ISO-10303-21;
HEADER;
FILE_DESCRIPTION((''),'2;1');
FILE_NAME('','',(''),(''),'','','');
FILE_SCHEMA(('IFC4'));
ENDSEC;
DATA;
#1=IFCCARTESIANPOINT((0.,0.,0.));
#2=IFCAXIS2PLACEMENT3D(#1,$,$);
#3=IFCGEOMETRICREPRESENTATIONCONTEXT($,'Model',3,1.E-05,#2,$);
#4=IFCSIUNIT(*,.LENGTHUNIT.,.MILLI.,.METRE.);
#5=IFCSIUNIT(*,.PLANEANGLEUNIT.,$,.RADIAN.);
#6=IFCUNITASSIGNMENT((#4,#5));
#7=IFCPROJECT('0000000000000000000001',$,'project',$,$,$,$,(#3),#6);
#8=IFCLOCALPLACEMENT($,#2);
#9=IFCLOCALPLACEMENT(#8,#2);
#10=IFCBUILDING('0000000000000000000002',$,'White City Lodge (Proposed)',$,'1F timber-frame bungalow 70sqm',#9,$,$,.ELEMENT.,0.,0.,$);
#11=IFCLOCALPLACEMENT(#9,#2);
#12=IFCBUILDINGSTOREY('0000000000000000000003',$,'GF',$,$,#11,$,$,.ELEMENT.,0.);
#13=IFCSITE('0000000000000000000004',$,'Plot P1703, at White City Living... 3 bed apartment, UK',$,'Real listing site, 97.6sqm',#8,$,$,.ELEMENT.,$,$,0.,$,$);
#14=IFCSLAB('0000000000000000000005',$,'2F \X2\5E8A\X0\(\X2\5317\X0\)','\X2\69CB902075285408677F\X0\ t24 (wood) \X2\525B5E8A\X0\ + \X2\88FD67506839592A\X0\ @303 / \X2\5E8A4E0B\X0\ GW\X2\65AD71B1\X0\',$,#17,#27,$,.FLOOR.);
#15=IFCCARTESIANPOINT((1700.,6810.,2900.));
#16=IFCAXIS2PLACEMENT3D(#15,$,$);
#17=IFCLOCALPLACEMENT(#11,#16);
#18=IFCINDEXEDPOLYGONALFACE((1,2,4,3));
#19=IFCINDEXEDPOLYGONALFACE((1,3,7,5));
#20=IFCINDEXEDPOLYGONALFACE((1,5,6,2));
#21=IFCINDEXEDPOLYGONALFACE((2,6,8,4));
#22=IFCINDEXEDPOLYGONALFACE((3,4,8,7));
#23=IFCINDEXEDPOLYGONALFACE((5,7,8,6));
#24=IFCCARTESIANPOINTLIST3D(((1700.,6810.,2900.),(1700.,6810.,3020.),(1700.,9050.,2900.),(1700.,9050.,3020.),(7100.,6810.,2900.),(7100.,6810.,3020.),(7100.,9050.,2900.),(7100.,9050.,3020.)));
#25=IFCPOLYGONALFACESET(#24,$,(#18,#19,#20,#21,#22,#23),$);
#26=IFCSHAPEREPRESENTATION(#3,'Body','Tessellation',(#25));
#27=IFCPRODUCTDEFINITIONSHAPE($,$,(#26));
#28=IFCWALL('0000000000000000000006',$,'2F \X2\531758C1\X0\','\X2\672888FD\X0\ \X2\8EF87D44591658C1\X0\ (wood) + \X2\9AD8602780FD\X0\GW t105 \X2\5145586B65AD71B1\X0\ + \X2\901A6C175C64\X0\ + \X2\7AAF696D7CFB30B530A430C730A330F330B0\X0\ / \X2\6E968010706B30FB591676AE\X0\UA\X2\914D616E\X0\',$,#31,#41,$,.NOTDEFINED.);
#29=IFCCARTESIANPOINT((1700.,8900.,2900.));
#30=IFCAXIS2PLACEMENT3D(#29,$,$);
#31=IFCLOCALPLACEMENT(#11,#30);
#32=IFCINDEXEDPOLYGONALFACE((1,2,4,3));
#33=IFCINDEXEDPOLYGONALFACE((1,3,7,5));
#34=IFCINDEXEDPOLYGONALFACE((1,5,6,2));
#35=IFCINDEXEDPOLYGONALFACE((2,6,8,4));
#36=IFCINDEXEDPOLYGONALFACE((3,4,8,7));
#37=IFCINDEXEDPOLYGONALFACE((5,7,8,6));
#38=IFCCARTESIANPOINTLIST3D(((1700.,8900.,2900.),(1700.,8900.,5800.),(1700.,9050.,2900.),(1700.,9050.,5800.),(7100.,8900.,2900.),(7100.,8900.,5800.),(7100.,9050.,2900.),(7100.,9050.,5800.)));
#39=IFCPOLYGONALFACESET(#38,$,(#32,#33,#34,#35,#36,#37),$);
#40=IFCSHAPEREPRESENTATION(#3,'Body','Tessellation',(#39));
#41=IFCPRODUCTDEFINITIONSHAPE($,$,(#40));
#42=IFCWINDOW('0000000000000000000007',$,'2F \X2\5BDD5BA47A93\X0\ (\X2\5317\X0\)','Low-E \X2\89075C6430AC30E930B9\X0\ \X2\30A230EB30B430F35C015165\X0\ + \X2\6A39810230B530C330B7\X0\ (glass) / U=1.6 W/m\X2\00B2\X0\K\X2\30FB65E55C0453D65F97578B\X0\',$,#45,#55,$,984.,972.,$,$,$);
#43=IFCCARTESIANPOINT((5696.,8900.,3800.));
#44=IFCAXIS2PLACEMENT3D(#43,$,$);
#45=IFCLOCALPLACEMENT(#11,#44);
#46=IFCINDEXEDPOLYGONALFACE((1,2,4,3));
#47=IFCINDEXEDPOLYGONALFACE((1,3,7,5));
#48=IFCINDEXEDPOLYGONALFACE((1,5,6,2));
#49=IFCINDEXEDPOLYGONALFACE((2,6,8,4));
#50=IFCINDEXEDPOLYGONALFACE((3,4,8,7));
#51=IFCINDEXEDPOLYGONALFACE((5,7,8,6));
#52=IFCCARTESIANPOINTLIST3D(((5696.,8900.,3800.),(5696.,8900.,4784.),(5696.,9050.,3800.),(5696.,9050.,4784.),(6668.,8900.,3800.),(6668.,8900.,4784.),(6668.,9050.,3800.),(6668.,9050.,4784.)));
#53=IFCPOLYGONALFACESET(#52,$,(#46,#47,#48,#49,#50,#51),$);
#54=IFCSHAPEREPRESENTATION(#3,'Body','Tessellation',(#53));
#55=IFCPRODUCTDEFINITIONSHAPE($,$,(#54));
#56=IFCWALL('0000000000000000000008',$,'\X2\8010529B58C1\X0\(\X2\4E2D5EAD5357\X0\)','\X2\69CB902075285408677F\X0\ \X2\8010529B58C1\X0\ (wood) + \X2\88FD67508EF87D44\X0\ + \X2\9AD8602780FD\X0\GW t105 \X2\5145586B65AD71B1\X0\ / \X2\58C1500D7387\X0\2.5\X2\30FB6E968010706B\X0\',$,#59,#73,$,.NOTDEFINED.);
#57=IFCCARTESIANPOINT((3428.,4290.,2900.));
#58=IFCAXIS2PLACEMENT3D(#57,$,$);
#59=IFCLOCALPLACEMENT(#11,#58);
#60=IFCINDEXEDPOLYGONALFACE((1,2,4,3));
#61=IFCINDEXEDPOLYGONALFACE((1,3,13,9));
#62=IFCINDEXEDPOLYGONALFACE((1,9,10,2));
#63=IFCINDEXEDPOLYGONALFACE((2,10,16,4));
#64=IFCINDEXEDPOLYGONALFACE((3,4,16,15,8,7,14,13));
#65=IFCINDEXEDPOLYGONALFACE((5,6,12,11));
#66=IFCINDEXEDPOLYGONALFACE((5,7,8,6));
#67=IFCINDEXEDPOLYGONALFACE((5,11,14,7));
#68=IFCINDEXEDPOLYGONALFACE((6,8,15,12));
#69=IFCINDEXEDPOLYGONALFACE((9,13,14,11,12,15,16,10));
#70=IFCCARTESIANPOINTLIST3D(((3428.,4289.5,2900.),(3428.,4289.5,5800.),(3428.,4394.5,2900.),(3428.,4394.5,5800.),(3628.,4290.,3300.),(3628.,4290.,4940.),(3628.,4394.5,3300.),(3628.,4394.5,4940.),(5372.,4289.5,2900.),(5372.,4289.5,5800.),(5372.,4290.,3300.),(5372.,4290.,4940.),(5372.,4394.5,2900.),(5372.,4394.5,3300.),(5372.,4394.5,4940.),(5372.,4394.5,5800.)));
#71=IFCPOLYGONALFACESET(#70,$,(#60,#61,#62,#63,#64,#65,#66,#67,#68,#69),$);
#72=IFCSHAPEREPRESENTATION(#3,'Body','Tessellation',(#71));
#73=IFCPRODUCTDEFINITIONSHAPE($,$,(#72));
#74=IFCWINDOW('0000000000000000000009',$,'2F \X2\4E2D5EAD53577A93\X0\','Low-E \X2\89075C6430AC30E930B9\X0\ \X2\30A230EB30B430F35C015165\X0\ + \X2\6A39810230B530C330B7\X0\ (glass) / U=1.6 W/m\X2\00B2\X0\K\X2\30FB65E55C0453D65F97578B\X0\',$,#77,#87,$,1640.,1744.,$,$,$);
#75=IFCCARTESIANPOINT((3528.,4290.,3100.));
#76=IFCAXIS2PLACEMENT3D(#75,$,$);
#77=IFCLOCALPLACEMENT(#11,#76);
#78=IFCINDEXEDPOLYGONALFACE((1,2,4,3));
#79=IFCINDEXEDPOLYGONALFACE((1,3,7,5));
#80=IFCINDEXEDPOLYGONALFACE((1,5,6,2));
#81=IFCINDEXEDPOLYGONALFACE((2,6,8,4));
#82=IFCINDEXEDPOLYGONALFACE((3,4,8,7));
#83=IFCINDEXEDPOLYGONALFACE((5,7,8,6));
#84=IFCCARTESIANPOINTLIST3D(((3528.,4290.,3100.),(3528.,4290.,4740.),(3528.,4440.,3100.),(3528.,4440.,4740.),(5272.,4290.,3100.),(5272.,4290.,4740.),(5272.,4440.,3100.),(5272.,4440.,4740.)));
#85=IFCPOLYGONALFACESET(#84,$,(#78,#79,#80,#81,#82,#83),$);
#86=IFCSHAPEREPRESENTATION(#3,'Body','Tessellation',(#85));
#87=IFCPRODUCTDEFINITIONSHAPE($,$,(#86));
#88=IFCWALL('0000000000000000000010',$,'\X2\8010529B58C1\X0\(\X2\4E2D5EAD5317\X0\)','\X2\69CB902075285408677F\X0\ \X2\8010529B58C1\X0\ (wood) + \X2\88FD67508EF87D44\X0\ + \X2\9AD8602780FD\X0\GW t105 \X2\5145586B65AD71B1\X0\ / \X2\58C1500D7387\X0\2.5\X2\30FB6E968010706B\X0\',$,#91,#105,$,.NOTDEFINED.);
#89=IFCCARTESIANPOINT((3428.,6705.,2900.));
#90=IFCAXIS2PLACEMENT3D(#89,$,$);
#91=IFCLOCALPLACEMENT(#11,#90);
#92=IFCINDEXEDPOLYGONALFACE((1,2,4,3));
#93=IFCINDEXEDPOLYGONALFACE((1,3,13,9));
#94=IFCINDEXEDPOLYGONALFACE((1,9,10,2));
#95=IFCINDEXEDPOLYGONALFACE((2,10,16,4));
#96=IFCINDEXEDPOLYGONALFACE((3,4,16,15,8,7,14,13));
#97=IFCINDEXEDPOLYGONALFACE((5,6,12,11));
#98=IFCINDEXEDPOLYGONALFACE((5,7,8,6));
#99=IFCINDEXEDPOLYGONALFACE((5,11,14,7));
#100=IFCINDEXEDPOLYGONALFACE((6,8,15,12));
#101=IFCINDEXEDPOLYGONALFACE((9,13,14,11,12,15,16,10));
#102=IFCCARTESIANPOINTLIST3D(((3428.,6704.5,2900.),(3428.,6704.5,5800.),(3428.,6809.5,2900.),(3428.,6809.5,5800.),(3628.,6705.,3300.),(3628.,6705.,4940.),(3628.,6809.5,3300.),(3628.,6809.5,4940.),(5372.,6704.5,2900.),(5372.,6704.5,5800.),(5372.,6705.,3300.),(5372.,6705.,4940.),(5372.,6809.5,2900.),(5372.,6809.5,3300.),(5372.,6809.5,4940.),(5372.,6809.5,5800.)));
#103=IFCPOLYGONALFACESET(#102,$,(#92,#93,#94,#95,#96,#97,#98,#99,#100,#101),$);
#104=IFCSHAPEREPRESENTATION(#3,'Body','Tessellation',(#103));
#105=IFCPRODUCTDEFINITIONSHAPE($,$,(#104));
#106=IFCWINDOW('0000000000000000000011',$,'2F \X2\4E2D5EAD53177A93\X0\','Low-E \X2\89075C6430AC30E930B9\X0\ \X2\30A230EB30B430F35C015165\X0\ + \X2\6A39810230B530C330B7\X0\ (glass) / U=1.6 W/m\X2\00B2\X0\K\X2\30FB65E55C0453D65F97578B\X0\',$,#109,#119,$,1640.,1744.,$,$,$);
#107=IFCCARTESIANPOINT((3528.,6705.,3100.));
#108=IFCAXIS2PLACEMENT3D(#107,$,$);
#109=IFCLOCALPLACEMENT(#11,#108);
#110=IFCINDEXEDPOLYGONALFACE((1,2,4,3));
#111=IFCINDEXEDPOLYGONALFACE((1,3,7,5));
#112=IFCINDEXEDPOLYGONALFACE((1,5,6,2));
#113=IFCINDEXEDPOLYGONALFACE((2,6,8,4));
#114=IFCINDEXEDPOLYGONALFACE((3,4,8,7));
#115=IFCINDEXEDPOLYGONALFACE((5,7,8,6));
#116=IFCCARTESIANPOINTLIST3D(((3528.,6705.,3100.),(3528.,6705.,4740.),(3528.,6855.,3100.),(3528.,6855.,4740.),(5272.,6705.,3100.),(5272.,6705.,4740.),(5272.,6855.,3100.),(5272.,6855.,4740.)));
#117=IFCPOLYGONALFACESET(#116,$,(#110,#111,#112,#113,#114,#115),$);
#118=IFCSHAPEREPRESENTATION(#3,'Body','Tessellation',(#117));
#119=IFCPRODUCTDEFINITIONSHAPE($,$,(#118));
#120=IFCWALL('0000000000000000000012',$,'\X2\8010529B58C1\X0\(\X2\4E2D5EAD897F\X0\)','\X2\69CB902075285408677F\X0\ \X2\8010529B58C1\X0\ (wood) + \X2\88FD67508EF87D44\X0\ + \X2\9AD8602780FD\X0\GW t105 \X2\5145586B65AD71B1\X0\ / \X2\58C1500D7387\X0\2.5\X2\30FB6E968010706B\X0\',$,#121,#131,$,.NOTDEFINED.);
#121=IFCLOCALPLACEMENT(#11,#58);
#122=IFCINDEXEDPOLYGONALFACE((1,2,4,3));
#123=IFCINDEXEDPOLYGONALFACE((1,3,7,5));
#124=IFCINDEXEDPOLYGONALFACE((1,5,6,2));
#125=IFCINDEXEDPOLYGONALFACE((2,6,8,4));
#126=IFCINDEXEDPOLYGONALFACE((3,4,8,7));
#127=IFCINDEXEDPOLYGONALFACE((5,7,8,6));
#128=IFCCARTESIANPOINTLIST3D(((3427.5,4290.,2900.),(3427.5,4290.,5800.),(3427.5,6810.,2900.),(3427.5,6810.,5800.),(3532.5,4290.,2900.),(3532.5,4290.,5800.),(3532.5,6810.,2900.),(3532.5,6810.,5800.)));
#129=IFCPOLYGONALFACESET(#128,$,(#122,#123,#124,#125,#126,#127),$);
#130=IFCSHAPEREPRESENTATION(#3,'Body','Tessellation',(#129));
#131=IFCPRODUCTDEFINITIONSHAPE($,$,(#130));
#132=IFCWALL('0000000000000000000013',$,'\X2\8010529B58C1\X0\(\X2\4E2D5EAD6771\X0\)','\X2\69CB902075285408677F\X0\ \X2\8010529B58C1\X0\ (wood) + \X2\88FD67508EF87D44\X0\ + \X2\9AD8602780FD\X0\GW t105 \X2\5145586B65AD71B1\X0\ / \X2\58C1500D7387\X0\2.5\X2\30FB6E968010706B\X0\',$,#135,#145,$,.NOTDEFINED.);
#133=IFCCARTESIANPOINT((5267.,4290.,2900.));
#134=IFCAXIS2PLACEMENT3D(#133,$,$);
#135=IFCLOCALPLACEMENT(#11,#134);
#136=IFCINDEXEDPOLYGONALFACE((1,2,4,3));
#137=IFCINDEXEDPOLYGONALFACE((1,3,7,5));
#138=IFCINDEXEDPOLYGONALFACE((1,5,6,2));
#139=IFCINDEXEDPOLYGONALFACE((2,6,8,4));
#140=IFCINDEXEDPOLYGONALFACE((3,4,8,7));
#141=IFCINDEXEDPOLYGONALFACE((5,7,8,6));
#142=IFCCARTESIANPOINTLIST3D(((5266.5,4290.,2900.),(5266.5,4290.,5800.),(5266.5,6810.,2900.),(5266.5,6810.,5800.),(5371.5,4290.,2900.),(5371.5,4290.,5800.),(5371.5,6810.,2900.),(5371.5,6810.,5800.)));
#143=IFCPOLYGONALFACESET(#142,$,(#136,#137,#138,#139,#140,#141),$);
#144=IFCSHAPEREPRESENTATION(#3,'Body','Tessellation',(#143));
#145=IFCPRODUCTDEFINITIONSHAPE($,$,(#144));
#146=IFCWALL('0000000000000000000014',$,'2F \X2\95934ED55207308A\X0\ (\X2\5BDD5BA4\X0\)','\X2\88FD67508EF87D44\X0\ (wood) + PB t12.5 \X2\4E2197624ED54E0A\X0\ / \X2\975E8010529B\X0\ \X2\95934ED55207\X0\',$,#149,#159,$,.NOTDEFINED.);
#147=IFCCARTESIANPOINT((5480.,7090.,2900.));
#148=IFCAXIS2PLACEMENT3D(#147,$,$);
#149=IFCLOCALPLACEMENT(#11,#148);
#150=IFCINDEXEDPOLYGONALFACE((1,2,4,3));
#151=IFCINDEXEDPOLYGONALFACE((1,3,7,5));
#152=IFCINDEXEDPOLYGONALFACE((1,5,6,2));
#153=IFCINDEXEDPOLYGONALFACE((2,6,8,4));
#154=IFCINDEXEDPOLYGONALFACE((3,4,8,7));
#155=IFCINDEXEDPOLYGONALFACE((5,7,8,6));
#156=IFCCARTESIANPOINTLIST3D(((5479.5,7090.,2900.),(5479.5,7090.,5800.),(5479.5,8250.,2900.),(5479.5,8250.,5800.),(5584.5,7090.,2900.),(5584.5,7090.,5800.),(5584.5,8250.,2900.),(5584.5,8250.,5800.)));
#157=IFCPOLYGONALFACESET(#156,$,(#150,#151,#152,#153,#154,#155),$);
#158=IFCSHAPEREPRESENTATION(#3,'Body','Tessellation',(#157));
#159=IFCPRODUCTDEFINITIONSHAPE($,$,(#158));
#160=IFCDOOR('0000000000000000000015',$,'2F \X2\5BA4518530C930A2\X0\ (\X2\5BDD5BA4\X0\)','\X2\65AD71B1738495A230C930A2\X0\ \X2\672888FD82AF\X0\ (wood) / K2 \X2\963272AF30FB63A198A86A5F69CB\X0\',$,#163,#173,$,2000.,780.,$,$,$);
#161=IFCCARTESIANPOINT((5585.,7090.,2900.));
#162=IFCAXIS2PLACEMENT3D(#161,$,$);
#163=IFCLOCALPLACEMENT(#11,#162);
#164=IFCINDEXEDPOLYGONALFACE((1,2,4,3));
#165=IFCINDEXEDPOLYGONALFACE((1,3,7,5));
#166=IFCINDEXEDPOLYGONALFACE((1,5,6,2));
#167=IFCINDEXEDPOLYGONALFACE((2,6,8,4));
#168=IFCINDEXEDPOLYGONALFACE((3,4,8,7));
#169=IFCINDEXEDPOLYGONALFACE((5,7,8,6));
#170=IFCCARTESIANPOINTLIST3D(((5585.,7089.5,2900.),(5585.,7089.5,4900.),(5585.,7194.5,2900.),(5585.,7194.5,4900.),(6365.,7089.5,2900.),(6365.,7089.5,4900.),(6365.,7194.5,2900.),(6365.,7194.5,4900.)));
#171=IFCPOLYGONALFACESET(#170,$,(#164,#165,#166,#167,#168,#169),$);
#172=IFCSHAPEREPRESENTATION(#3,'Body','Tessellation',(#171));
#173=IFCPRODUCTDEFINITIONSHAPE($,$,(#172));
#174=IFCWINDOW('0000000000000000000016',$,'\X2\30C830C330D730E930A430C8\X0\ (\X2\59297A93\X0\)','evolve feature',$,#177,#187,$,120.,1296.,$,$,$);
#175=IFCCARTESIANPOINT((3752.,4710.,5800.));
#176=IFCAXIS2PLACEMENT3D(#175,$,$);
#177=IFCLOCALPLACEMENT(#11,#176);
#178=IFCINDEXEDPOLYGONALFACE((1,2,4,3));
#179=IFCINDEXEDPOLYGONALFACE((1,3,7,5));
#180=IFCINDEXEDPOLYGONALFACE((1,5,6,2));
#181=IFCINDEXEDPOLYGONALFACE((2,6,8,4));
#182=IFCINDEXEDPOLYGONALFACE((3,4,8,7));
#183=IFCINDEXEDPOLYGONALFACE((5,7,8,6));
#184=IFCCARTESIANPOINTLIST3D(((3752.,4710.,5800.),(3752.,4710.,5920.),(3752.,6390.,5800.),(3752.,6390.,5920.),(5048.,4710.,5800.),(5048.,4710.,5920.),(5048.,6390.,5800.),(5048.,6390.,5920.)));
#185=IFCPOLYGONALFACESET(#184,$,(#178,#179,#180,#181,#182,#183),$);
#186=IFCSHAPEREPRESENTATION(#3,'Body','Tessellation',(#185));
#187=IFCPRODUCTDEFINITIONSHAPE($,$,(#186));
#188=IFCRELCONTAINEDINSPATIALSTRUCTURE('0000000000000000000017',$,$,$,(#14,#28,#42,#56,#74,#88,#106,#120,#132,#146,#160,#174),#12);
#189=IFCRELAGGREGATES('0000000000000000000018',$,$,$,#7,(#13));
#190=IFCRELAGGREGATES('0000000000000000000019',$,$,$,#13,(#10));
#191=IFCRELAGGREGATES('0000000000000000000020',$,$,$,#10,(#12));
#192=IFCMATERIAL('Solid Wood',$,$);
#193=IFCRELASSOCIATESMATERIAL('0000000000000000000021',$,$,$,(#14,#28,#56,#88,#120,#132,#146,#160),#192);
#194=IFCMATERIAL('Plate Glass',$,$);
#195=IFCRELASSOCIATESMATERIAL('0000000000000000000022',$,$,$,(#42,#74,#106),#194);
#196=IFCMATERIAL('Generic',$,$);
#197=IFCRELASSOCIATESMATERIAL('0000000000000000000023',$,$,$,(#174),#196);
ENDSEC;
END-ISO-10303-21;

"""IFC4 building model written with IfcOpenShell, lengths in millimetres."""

from ifc_helpers import new_model, si_unit, frame, frame_2d, origin, place, context, project, spatial, rectangle, extrude, material, element, fill, save


model = new_model("IFC4")

# Units and contexts
model_context = context("Model", 3, precision=1e-05, world=origin())
ifc_project = project(units=[si_unit("LENGTHUNIT", "METRE", prefix="MILLI"), si_unit("PLANEANGLEUNIT", "RADIAN")], contexts=[model_context])

# Site, building, storey
site_placement = place(None, origin())
site = spatial("IfcSite", under=ifc_project, at=site_placement, Name="Plot P1703, at White City Living... 3 bed apartment, UK", ObjectType="Real listing site, 97.6sqm", CompositionType="ELEMENT", RefElevation=0.0)
building_placement = place(site_placement, origin())
building = spatial("IfcBuilding", under=site, at=building_placement, Name="White City Lodge (Proposed)", ObjectType="1F timber-frame bungalow 70sqm", CompositionType="ELEMENT", ElevationOfRefHeight=0.0, ElevationOfTerrain=0.0)
storey_placement = place(building_placement, origin())
storey = spatial("IfcBuildingStorey", under=building, at=storey_placement, Name="GF", CompositionType="ELEMENT", Elevation=0.0)

# Slab
ifc_material_1 = material(Name="Solid Wood")
slab_placement = place(storey_placement, frame((1700.0, 6810.0, 2900.0)))
element("IfcSlab", 1, at=slab_placement, inside=storey, material=ifc_material_1, Name="2F 床(北)", Description="構造用合板 t24 (wood) 剛床 + 製材根太 @303 / 床下 GW断熱", PredefinedType="FLOOR", context=model_context, shape_type="SweptSolid", body=[
    extrude(rectangle(XDim=5400.0, YDim=2240.0, at=frame_2d((2700.0, 1120.0))), frame((1700.0, 6810.0, 2900.0)), (0.0, 0.0, 1.0), 120.0),
])

# Walls, openings, windows
wall_1_placement = place(storey_placement, frame((1700.0, 8900.0, 2900.0)))
wall_1 = element("IfcWall", 2, at=wall_1_placement, inside=storey, material=ifc_material_1, Name="2F 北壁", Description="木製 軸組外壁 (wood) + 高性能GW t105 充填断熱 + 通気層 + 窯業系サイディング / 準耐火・外皮UA配慮", PredefinedType="NOTDEFINED", context=model_context, shape_type="SweptSolid", body=[
    extrude(rectangle(XDim=5400.0, YDim=150.0, at=frame_2d((2700.0, 75.0))), frame((1700.0, 8900.0, 2900.0)), (0.0, 0.0, 1.0), 2900.0),
])
opening_1_placement = place(storey_placement, frame((5696.0, 8900.0, 3800.0)))
opening_1 = element("IfcOpeningElement", 3, at=opening_1_placement, cuts=wall_1, PredefinedType="NOTDEFINED", context=model_context, shape_type="SweptSolid", body=[
    extrude(rectangle(XDim=972.0, YDim=150.0, at=frame_2d((486.0, 75.0))), frame((5696.0, 8900.0, 3800.0)), (0.0, 0.0, 1.0), 984.0),
])
ifc_material_2 = material(Name="Plate Glass")
window_1_placement = place(storey_placement, frame((5696.0, 8900.0, 3800.0)))
window_1 = element("IfcWindow", 4, at=window_1_placement, inside=storey, material=ifc_material_2, Name="2F 寝室窓 (北)", Description="Low-E 複層ガラス アルゴン封入 + 樹脂サッシ (glass) / U=1.6 W/m²K・日射取得型", OverallHeight=984.0, OverallWidth=972.0, context=model_context, shape_type="SweptSolid", body=[
    extrude(rectangle(XDim=972.0, YDim=150.0, at=frame_2d((486.0, 75.0))), frame((5696.0, 8900.0, 3800.0)), (0.0, 0.0, 1.0), 984.0),
])
fill(opening_1, window_1)
wall_2_placement = place(storey_placement, frame((3428.0, 4290.0, 2900.0)))
wall_2 = element("IfcWall", 5, at=wall_2_placement, inside=storey, material=ifc_material_1, Name="耐力壁(中庭南)", Description="構造用合板 耐力壁 (wood) + 製材軸組 + 高性能GW t105 充填断熱 / 壁倍率2.5・準耐火", PredefinedType="NOTDEFINED", context=model_context, shape_type="SweptSolid", body=[
    extrude(rectangle(XDim=1944.0, YDim=105.0, at=frame_2d((972.0, 52.0))), frame((3428.0, 4290.0, 2900.0)), (0.0, 0.0, 1.0), 2900.0),
])
opening_2_placement = place(storey_placement, frame((3528.0, 4290.0, 3100.0)))
opening_2 = element("IfcOpeningElement", 6, at=opening_2_placement, cuts=wall_2, PredefinedType="NOTDEFINED", context=model_context, shape_type="SweptSolid", body=[
    extrude(rectangle(XDim=1744.0, YDim=150.0, at=frame_2d((872.0, 75.0))), frame((3528.0, 4290.0, 3100.0)), (0.0, 0.0, 1.0), 1640.0),
])
window_2_placement = place(storey_placement, frame((3528.0, 4290.0, 3100.0)))
window_2 = element("IfcWindow", 7, at=window_2_placement, inside=storey, material=ifc_material_2, Name="2F 中庭南窓", Description="Low-E 複層ガラス アルゴン封入 + 樹脂サッシ (glass) / U=1.6 W/m²K・日射取得型", OverallHeight=1640.0, OverallWidth=1744.0, context=model_context, shape_type="SweptSolid", body=[
    extrude(rectangle(XDim=1744.0, YDim=150.0, at=frame_2d((872.0, 75.0))), frame((3528.0, 4290.0, 3100.0)), (0.0, 0.0, 1.0), 1640.0),
])
fill(opening_2, window_2)
wall_3_placement = place(storey_placement, frame((3428.0, 6705.0, 2900.0)))
wall_3 = element("IfcWall", 8, at=wall_3_placement, inside=storey, material=ifc_material_1, Name="耐力壁(中庭北)", Description="構造用合板 耐力壁 (wood) + 製材軸組 + 高性能GW t105 充填断熱 / 壁倍率2.5・準耐火", PredefinedType="NOTDEFINED", context=model_context, shape_type="SweptSolid", body=[
    extrude(rectangle(XDim=1944.0, YDim=105.0, at=frame_2d((972.0, 52.0))), frame((3428.0, 6705.0, 2900.0)), (0.0, 0.0, 1.0), 2900.0),
])
opening_3_placement = place(storey_placement, frame((3528.0, 6705.0, 3100.0)))
opening_3 = element("IfcOpeningElement", 9, at=opening_3_placement, cuts=wall_3, PredefinedType="NOTDEFINED", context=model_context, shape_type="SweptSolid", body=[
    extrude(rectangle(XDim=1744.0, YDim=150.0, at=frame_2d((872.0, 75.0))), frame((3528.0, 6705.0, 3100.0)), (0.0, 0.0, 1.0), 1640.0),
])
window_3_placement = place(storey_placement, frame((3528.0, 6705.0, 3100.0)))
window_3 = element("IfcWindow", 10, at=window_3_placement, inside=storey, material=ifc_material_2, Name="2F 中庭北窓", Description="Low-E 複層ガラス アルゴン封入 + 樹脂サッシ (glass) / U=1.6 W/m²K・日射取得型", OverallHeight=1640.0, OverallWidth=1744.0, context=model_context, shape_type="SweptSolid", body=[
    extrude(rectangle(XDim=1744.0, YDim=150.0, at=frame_2d((872.0, 75.0))), frame((3528.0, 6705.0, 3100.0)), (0.0, 0.0, 1.0), 1640.0),
])
fill(opening_3, window_3)

# Walls
wall_4_placement = place(storey_placement, frame((3428.0, 4290.0, 2900.0)))
element("IfcWall", 11, at=wall_4_placement, inside=storey, material=ifc_material_1, Name="耐力壁(中庭西)", Description="構造用合板 耐力壁 (wood) + 製材軸組 + 高性能GW t105 充填断熱 / 壁倍率2.5・準耐火", PredefinedType="NOTDEFINED", context=model_context, shape_type="SweptSolid", body=[
    extrude(rectangle(XDim=105.0, YDim=2520.0, at=frame_2d((52.0, 1260.0))), frame((3428.0, 4290.0, 2900.0)), (0.0, 0.0, 1.0), 2900.0),
])
wall_5_placement = place(storey_placement, frame((5267.0, 4290.0, 2900.0)))
element("IfcWall", 12, at=wall_5_placement, inside=storey, material=ifc_material_1, Name="耐力壁(中庭東)", Description="構造用合板 耐力壁 (wood) + 製材軸組 + 高性能GW t105 充填断熱 / 壁倍率2.5・準耐火", PredefinedType="NOTDEFINED", context=model_context, shape_type="SweptSolid", body=[
    extrude(rectangle(XDim=105.0, YDim=2520.0, at=frame_2d((52.0, 1260.0))), frame((5267.0, 4290.0, 2900.0)), (0.0, 0.0, 1.0), 2900.0),
])
wall_6_placement = place(storey_placement, frame((5480.0, 7090.0, 2900.0)))
element("IfcWall", 13, at=wall_6_placement, inside=storey, material=ifc_material_1, Name="2F 間仕切り (寝室)", Description="製材軸組 (wood) + PB t12.5 両面仕上 / 非耐力 間仕切", PredefinedType="NOTDEFINED", context=model_context, shape_type="SweptSolid", body=[
    extrude(rectangle(XDim=105.0, YDim=1160.0, at=frame_2d((52.0, 580.0))), frame((5480.0, 7090.0, 2900.0)), (0.0, 0.0, 1.0), 2900.0),
])

# Door
door_placement = place(storey_placement, frame((5585.0, 7090.0, 2900.0)))
element("IfcDoor", 14, at=door_placement, inside=storey, material=ifc_material_1, Name="2F 室内ドア (寝室)", Description="断熱玄関ドア 木製芯 (wood) / K2 防犯・採風機構", OverallHeight=2000.0, OverallWidth=780.0, context=model_context, shape_type="SweptSolid", body=[
    extrude(rectangle(XDim=780.0, YDim=105.0, at=frame_2d((390.0, 52.0))), frame((5585.0, 7090.0, 2900.0)), (0.0, 0.0, 1.0), 2000.0),
])

# Window
ifc_material_3 = material(Name="Generic")
window_4_placement = place(storey_placement, frame((3752.0, 4710.0, 5800.0)))
element("IfcWindow", 15, at=window_4_placement, inside=storey, material=ifc_material_3, Name="トップライト (天窓)", Description="evolve feature", OverallHeight=120.0, OverallWidth=1296.0, context=model_context, shape_type="SweptSolid", body=[
    extrude(rectangle(XDim=1296.0, YDim=1680.0, at=frame_2d((648.0, 840.0))), frame((3752.0, 4710.0, 5800.0)), (0.0, 0.0, 1.0), 120.0),
])

save(model, "model.ifc")
